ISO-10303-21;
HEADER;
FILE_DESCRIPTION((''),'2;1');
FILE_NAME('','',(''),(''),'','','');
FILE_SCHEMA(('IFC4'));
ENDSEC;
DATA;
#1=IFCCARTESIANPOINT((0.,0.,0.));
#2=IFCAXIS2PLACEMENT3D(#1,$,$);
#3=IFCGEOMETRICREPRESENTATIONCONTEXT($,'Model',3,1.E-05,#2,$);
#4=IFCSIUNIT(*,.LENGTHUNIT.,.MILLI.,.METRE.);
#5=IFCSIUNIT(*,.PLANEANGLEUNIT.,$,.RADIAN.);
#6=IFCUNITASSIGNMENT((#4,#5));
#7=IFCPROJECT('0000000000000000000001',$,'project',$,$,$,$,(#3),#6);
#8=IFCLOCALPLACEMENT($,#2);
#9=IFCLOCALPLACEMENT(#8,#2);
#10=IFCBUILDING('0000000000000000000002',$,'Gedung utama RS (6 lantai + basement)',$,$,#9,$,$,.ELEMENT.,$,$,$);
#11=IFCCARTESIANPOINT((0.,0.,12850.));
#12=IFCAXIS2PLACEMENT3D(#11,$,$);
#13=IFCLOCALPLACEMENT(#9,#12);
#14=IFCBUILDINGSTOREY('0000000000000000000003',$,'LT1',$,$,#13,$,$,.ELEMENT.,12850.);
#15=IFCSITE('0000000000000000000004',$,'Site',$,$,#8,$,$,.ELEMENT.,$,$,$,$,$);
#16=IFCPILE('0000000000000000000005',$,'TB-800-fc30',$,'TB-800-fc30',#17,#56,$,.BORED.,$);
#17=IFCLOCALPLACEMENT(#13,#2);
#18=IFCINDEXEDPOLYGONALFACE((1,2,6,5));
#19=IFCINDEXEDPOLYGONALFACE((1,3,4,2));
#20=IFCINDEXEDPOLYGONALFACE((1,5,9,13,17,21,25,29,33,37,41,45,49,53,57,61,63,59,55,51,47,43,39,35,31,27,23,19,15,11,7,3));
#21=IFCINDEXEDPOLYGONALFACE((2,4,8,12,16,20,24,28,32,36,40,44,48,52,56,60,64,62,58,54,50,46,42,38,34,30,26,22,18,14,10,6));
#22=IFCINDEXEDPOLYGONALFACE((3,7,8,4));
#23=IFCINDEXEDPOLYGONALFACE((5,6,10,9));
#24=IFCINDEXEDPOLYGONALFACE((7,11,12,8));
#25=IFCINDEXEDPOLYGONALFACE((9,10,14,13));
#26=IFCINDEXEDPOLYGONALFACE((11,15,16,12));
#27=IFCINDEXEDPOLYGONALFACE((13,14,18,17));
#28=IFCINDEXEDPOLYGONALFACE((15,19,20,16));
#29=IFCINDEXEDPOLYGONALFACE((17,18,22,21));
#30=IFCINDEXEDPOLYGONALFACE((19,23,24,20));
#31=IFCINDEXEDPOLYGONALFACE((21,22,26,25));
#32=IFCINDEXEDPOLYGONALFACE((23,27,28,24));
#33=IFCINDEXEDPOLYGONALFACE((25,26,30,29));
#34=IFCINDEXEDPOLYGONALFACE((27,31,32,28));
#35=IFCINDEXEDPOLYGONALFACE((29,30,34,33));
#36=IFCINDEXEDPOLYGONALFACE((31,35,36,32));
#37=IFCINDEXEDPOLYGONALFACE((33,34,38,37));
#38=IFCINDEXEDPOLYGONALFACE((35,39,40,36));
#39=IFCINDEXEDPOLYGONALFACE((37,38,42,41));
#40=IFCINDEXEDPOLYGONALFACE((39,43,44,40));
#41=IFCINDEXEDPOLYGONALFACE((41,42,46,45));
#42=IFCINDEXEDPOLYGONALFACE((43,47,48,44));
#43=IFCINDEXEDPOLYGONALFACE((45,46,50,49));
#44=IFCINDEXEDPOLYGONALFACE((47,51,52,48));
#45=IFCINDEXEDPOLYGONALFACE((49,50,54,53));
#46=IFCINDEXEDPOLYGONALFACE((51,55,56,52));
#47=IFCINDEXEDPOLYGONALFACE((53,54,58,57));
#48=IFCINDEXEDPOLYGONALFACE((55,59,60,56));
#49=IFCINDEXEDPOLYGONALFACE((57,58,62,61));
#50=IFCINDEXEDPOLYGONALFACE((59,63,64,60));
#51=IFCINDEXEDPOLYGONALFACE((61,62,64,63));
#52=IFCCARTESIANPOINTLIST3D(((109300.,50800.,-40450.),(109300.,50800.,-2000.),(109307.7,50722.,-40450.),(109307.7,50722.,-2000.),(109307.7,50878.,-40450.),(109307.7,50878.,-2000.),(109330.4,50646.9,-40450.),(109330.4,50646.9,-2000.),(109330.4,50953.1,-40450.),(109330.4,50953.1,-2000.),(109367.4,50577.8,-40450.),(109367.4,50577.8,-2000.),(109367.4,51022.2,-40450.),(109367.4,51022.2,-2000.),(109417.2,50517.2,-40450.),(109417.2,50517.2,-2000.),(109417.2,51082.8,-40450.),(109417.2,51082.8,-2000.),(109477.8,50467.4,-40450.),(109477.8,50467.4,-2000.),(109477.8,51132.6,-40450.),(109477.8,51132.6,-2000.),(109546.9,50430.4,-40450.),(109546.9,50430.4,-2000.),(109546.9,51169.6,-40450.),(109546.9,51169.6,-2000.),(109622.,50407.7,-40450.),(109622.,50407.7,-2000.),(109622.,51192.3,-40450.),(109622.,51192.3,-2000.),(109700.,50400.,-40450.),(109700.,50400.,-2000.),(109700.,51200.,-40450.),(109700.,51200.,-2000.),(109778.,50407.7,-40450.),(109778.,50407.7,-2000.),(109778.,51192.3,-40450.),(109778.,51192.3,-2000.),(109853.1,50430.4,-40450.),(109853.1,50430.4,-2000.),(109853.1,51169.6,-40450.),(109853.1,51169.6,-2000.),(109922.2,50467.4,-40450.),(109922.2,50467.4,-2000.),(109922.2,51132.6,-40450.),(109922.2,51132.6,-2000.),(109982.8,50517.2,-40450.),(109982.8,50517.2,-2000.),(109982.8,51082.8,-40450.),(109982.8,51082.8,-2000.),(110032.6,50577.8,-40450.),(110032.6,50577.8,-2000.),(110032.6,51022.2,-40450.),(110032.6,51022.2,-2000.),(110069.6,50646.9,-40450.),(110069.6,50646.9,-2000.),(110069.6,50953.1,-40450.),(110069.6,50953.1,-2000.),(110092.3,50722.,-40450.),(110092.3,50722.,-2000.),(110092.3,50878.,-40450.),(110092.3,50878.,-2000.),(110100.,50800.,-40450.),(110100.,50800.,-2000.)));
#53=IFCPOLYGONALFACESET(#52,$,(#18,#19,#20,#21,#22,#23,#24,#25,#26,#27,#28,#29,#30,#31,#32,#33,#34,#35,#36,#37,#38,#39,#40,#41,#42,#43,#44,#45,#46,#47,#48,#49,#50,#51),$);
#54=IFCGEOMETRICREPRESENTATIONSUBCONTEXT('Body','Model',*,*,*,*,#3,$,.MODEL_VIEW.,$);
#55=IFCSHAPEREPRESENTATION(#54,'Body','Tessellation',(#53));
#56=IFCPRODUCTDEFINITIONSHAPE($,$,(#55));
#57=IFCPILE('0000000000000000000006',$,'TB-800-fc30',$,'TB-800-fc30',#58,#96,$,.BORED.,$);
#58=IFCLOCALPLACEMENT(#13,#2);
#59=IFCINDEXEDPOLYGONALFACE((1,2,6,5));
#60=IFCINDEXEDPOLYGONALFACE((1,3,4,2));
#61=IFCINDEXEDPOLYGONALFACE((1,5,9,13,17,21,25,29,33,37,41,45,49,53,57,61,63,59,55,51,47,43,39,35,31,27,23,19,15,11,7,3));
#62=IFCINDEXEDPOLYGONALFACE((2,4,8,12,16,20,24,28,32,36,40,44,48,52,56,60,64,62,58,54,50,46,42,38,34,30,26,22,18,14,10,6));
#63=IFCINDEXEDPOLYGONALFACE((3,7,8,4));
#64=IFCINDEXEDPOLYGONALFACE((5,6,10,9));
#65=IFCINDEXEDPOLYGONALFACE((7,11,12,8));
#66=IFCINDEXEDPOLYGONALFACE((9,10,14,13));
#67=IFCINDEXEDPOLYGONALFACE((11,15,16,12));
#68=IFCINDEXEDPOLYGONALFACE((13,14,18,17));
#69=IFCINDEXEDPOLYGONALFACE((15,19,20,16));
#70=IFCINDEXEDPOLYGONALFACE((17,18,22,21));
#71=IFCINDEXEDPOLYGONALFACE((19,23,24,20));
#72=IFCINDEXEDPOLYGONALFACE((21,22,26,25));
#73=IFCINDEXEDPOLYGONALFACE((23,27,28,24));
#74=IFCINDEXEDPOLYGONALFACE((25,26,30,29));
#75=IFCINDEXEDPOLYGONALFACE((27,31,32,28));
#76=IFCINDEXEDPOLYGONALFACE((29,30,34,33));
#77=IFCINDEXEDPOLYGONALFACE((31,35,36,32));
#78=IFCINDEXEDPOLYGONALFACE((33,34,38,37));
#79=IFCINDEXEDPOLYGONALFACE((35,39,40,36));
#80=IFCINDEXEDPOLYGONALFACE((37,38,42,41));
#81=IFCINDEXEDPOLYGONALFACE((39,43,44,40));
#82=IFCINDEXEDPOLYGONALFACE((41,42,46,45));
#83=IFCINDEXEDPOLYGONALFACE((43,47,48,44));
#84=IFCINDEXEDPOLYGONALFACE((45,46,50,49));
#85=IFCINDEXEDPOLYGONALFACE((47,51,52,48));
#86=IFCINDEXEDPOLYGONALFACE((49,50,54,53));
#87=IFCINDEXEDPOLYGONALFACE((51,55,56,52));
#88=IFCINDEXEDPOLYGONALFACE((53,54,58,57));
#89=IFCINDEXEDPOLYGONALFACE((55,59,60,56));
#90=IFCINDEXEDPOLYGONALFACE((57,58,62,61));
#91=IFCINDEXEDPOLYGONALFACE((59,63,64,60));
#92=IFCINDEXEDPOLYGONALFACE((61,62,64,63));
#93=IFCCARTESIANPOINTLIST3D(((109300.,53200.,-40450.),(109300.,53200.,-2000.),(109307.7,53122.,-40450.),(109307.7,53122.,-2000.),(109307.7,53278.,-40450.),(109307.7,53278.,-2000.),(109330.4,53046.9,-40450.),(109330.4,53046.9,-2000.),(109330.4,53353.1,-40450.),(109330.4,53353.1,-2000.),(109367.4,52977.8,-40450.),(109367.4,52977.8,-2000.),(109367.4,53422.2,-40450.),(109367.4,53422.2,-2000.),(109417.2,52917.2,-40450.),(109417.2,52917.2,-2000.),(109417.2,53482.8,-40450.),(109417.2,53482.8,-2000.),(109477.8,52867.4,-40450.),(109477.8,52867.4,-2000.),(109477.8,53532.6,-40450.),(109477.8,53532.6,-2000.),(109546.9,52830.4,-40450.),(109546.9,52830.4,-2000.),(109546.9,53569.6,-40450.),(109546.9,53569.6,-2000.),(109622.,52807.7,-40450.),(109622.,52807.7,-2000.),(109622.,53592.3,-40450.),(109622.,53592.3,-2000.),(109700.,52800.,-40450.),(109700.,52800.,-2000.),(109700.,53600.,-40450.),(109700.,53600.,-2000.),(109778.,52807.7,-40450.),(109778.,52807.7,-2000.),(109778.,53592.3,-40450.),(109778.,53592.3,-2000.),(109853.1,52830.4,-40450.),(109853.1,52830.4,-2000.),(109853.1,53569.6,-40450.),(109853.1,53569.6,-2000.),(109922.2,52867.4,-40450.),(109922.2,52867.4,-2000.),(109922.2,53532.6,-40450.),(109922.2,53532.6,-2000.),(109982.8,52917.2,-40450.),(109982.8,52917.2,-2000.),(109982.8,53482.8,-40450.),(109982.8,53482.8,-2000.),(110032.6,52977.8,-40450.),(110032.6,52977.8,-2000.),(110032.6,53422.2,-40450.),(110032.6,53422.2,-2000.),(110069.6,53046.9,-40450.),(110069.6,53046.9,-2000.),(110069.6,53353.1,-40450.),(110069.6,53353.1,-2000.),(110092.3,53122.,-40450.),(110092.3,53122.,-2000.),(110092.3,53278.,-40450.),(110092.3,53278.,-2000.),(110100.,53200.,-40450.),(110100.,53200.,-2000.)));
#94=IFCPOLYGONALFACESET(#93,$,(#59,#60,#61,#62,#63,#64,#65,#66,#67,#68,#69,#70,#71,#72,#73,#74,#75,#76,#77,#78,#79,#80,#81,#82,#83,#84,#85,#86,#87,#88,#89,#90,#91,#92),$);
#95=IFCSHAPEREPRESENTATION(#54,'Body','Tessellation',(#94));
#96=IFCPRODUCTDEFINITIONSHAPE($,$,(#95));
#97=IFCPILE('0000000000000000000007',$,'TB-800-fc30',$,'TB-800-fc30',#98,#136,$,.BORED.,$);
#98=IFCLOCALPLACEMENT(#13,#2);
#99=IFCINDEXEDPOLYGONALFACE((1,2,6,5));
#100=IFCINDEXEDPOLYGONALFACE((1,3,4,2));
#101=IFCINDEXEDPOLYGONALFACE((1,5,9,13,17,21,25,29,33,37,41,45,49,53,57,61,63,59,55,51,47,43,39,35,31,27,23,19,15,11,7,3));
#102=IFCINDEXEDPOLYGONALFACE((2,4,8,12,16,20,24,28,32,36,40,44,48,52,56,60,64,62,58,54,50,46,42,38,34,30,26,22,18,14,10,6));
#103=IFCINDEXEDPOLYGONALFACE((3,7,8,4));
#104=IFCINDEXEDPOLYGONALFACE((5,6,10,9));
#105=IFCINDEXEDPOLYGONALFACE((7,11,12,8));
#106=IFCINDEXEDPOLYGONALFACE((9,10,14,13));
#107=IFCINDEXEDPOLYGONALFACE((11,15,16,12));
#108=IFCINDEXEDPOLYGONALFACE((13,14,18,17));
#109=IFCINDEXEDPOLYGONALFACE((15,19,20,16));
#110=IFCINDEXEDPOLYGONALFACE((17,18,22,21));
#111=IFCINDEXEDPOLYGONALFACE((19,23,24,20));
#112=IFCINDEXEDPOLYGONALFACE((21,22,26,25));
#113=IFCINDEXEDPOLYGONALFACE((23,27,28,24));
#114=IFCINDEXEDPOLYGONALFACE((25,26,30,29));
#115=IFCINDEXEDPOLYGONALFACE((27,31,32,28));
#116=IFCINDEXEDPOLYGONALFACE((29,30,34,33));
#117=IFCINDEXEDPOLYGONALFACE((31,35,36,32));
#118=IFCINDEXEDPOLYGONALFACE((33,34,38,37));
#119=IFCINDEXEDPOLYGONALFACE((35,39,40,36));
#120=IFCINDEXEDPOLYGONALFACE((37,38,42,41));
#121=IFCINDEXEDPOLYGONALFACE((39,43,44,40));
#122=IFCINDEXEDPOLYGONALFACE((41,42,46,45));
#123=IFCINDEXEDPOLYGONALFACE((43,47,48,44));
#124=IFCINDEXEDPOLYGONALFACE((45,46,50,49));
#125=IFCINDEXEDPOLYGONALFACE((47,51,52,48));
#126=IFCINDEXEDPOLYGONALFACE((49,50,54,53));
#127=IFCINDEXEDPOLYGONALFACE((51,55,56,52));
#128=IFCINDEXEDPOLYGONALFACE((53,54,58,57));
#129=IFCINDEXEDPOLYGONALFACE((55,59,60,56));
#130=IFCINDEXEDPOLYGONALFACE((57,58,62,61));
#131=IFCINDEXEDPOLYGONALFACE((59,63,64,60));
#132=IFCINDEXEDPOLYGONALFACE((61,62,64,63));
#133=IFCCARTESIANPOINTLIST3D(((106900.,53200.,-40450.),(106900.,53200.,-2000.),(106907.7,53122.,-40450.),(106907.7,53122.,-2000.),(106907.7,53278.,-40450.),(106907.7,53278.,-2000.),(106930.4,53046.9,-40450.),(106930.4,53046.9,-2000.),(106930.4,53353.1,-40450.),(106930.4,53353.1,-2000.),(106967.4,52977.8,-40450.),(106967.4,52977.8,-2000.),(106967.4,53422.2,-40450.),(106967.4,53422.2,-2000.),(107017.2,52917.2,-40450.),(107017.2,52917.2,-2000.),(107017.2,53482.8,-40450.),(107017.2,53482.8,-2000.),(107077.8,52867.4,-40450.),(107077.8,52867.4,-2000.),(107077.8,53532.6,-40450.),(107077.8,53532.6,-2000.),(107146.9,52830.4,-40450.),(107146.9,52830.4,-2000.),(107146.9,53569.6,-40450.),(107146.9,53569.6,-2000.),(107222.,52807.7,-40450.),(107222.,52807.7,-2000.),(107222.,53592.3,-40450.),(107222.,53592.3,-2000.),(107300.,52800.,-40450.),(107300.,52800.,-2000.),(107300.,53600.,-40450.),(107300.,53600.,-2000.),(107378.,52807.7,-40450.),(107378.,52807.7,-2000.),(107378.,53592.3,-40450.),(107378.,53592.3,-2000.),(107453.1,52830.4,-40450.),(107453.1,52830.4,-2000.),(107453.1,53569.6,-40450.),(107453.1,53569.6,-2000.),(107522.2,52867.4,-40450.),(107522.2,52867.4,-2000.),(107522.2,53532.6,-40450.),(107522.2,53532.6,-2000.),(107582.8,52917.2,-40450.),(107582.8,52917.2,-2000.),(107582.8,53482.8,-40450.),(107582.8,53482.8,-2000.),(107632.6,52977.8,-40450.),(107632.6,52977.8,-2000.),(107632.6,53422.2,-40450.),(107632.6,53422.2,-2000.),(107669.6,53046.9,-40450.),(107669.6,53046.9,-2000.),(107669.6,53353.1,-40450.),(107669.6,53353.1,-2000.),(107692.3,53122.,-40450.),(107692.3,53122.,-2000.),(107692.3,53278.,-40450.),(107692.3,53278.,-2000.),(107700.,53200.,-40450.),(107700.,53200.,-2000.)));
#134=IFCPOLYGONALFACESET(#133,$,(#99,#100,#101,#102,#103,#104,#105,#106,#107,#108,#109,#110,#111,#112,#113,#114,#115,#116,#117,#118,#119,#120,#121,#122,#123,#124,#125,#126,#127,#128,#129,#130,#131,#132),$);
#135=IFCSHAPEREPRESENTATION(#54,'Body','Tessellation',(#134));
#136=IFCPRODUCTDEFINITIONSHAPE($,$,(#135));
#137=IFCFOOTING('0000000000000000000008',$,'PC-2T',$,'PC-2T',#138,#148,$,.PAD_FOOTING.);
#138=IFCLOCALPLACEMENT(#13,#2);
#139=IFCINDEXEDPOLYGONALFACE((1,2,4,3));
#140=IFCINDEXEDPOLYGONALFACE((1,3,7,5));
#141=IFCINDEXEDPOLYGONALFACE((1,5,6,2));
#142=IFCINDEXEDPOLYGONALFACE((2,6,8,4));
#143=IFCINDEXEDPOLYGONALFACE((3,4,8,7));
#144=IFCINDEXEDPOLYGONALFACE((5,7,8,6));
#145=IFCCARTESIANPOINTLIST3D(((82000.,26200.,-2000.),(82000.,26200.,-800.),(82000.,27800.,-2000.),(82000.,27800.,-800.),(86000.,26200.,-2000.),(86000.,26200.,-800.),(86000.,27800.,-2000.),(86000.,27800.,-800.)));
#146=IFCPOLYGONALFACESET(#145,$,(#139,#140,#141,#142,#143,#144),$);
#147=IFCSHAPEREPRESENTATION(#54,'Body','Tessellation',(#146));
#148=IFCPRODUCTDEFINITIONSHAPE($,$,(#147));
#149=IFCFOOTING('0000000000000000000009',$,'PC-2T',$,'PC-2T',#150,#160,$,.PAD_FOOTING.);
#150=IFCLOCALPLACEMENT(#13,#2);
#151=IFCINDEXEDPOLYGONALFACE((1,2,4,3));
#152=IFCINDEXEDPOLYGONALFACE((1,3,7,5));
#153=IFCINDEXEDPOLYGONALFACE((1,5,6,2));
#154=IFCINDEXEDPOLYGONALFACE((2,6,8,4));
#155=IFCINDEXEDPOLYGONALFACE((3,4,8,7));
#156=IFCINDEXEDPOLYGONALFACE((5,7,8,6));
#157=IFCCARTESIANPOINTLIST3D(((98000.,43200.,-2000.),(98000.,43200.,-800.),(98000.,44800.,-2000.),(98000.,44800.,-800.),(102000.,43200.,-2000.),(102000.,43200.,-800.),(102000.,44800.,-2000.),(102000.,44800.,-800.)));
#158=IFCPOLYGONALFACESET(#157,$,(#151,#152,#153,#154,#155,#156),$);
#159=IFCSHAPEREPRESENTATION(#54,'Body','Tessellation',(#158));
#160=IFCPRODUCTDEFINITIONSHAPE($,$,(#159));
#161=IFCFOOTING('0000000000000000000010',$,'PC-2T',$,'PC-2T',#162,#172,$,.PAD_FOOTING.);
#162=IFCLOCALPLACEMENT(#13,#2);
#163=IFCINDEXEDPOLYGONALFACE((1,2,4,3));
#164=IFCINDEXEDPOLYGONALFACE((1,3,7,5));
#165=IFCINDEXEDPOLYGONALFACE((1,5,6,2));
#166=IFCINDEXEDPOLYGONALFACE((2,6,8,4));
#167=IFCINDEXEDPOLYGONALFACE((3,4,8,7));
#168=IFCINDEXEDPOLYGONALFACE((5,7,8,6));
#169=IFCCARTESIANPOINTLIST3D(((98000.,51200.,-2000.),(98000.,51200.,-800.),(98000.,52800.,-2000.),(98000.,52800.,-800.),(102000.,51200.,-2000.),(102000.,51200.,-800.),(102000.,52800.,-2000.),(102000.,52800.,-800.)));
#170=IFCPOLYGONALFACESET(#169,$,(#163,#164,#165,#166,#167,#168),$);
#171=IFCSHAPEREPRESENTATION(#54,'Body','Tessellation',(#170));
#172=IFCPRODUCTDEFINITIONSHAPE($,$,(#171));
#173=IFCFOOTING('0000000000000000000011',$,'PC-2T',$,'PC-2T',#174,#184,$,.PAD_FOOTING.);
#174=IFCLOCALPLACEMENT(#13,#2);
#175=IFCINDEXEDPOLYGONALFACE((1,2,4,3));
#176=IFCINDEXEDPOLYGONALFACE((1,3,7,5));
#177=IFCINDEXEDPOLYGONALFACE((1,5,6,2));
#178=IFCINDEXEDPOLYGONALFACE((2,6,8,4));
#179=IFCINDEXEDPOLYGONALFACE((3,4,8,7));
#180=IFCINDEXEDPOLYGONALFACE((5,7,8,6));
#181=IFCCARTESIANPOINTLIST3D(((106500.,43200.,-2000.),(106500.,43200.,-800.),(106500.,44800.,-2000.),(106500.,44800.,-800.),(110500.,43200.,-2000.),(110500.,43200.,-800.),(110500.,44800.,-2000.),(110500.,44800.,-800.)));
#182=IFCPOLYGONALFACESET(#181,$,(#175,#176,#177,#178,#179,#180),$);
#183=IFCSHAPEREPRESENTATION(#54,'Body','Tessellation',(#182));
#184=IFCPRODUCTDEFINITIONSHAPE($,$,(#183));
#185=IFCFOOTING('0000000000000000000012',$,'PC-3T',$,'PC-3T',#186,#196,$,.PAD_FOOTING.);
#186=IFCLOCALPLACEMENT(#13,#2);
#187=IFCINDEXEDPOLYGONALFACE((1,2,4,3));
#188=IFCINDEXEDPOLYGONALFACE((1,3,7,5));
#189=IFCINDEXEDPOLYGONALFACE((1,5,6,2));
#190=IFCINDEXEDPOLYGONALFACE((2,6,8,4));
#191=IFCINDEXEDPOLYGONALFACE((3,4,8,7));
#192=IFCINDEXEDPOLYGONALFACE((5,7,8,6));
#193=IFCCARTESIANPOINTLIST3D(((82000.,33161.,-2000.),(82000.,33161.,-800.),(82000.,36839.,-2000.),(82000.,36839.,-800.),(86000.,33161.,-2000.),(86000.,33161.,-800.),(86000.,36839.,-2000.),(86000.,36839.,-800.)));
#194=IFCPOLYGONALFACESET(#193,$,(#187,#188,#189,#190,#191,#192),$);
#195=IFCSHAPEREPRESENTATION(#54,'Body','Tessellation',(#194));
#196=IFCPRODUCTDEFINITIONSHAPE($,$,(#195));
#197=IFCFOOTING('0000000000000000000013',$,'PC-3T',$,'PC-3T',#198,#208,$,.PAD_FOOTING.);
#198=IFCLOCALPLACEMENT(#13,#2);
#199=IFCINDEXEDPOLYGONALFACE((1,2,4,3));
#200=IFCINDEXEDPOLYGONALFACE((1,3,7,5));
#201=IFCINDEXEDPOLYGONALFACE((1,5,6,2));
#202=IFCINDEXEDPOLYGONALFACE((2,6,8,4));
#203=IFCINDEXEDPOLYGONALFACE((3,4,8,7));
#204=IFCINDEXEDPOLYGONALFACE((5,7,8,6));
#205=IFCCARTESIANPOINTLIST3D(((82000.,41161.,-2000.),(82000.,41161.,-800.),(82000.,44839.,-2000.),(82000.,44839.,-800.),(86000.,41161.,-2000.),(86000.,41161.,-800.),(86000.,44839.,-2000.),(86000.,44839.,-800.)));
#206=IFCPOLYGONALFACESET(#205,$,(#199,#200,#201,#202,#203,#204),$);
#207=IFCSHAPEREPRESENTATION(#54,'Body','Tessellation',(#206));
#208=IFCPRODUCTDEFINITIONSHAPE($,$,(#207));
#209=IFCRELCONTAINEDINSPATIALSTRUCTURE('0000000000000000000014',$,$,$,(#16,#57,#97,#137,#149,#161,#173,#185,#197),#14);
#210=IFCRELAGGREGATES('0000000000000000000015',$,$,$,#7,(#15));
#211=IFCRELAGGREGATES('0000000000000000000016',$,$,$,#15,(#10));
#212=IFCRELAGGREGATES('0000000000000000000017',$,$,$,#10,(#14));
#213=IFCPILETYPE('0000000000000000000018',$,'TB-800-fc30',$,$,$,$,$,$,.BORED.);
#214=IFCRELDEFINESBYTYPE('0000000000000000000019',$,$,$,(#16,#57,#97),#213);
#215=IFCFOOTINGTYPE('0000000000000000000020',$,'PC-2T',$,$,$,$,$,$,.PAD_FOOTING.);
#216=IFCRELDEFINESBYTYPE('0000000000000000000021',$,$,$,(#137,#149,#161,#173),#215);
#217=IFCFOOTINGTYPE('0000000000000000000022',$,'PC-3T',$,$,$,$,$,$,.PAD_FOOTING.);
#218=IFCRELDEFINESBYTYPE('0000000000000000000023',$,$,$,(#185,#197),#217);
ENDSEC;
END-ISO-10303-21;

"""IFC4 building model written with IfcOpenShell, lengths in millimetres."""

from ifc_helpers import new_model, si_unit, frame, origin, origin_2d, place, context, subcontext, project, spatial, rectangle, circle, extrude, material_profile, profile_set, profile_usage, type_object, element, save


model = new_model("IFC4")

# Units and contexts
model_context = context("Model", 3, precision=1e-05, world=origin())
body_context = subcontext(model_context, "Body", "Model", "MODEL_VIEW")
ifc_project = project(units=[si_unit("LENGTHUNIT", "METRE", prefix="MILLI"), si_unit("PLANEANGLEUNIT", "RADIAN")], contexts=[model_context])

# Site, building, storey
site_placement = place(None, origin())
site = spatial("IfcSite", under=ifc_project, at=site_placement, Name="Site", CompositionType="ELEMENT")
building_placement = place(site_placement, origin())
building = spatial("IfcBuilding", under=site, at=building_placement, Name="Gedung utama RS (6 lantai + basement)", CompositionType="ELEMENT")
storey_placement = place(building_placement, frame((0.0, 0.0, 12850.0)))
storey = spatial("IfcBuildingStorey", under=building, at=storey_placement, Name="LT1", CompositionType="ELEMENT", Elevation=12850.0)

# Piles
ifc_material_profile_1 = material_profile(None, circle(Radius=400.0, at=origin_2d()), Name="TB-800-fc30")
ifc_profile_set_1 = profile_set([ifc_material_profile_1], Name="TB-800-fc30")
ifc_profile_usage_1 = profile_usage(ifc_profile_set_1, cardinal=5)
pile_type = type_object("IfcPileType", Name="TB-800-fc30", PredefinedType="BORED", material=ifc_profile_set_1)
for number, where, z_axis, x_axis, name in (
    (1, (109700.0, 50800.0, -40450.0), (0.0, 0.0, 1.0), (1.0, 0.0, 0.0), "TB-800-fc30"),
    (2, (109700.0, 53200.0, -40450.0), (0.0, 0.0, 1.0), (1.0, 0.0, 0.0), "TB-800-fc30"),
    (3, (107300.0, 53200.0, -40450.0), (0.0, 0.0, 1.0), (1.0, 0.0, 0.0), "TB-800-fc30"),
):
    element("IfcPile", number, at=place(storey_placement, frame(where, z_axis=z_axis, x_axis=x_axis)), inside=storey, type_object=pile_type, material=ifc_profile_usage_1, Name=name, ObjectType="TB-800-fc30", PredefinedType="BORED", context=body_context, shape_type="SweptSolid", body=[
        extrude(circle(Radius=400.0, at=origin_2d()), origin(), (0.0, 0.0, 1.0), 38450.0),
    ])

# Footings
ifc_material_profile_2 = material_profile(None, rectangle(XDim=4000.0, YDim=1600.0, at=origin_2d()), Name="PC-2T")
ifc_profile_set_2 = profile_set([ifc_material_profile_2], Name="PC-2T")
ifc_profile_usage_2 = profile_usage(ifc_profile_set_2, cardinal=5)
footing_type_1 = type_object("IfcFootingType", Name="PC-2T", PredefinedType="PAD_FOOTING", material=ifc_profile_set_2)
for number, where, z_axis, x_axis, name in (
    (4, (84000.0, 27000.0, -2000.0), (0.0, 0.0, 1.0), (1.0, 0.0, 0.0), "PC-2T"),
    (5, (100000.0, 44000.0, -2000.0), (0.0, 0.0, 1.0), (1.0, 0.0, 0.0), "PC-2T"),
    (6, (100000.0, 52000.0, -2000.0), (0.0, 0.0, 1.0), (1.0, 0.0, 0.0), "PC-2T"),
    (7, (108500.0, 44000.0, -2000.0), (0.0, 0.0, 1.0), (1.0, 0.0, 0.0), "PC-2T"),
):
    element("IfcFooting", number, at=place(storey_placement, frame(where, z_axis=z_axis, x_axis=x_axis)), inside=storey, type_object=footing_type_1, material=ifc_profile_usage_2, Name=name, ObjectType="PC-2T", PredefinedType="PAD_FOOTING", context=body_context, shape_type="SweptSolid", body=[
        extrude(rectangle(XDim=4000.0, YDim=1600.0, at=origin_2d()), origin(), (0.0, 0.0, 1.0), 1200.0),
    ])
ifc_material_profile_3 = material_profile(None, rectangle(XDim=4000.0, YDim=3678.0, at=origin_2d()), Name="PC-3T")
ifc_profile_set_3 = profile_set([ifc_material_profile_3], Name="PC-3T")
ifc_profile_usage_3 = profile_usage(ifc_profile_set_3, cardinal=5)
footing_type_2 = type_object("IfcFootingType", Name="PC-3T", PredefinedType="PAD_FOOTING", material=ifc_profile_set_3)
for number, where, z_axis, x_axis, name in (
    (8, (84000.0, 35000.0, -2000.0), (0.0, 0.0, 1.0), (1.0, 0.0, 0.0), "PC-3T"),
    (9, (84000.0, 43000.0, -2000.0), (0.0, 0.0, 1.0), (1.0, 0.0, 0.0), "PC-3T"),
):
    element("IfcFooting", number, at=place(storey_placement, frame(where, z_axis=z_axis, x_axis=x_axis)), inside=storey, type_object=footing_type_2, material=ifc_profile_usage_3, Name=name, ObjectType="PC-3T", PredefinedType="PAD_FOOTING", context=body_context, shape_type="SweptSolid", body=[
        extrude(rectangle(XDim=4000.0, YDim=3678.0, at=origin_2d()), origin(), (0.0, 0.0, 1.0), 1200.0),
    ])

save(model, "model.ifc")
